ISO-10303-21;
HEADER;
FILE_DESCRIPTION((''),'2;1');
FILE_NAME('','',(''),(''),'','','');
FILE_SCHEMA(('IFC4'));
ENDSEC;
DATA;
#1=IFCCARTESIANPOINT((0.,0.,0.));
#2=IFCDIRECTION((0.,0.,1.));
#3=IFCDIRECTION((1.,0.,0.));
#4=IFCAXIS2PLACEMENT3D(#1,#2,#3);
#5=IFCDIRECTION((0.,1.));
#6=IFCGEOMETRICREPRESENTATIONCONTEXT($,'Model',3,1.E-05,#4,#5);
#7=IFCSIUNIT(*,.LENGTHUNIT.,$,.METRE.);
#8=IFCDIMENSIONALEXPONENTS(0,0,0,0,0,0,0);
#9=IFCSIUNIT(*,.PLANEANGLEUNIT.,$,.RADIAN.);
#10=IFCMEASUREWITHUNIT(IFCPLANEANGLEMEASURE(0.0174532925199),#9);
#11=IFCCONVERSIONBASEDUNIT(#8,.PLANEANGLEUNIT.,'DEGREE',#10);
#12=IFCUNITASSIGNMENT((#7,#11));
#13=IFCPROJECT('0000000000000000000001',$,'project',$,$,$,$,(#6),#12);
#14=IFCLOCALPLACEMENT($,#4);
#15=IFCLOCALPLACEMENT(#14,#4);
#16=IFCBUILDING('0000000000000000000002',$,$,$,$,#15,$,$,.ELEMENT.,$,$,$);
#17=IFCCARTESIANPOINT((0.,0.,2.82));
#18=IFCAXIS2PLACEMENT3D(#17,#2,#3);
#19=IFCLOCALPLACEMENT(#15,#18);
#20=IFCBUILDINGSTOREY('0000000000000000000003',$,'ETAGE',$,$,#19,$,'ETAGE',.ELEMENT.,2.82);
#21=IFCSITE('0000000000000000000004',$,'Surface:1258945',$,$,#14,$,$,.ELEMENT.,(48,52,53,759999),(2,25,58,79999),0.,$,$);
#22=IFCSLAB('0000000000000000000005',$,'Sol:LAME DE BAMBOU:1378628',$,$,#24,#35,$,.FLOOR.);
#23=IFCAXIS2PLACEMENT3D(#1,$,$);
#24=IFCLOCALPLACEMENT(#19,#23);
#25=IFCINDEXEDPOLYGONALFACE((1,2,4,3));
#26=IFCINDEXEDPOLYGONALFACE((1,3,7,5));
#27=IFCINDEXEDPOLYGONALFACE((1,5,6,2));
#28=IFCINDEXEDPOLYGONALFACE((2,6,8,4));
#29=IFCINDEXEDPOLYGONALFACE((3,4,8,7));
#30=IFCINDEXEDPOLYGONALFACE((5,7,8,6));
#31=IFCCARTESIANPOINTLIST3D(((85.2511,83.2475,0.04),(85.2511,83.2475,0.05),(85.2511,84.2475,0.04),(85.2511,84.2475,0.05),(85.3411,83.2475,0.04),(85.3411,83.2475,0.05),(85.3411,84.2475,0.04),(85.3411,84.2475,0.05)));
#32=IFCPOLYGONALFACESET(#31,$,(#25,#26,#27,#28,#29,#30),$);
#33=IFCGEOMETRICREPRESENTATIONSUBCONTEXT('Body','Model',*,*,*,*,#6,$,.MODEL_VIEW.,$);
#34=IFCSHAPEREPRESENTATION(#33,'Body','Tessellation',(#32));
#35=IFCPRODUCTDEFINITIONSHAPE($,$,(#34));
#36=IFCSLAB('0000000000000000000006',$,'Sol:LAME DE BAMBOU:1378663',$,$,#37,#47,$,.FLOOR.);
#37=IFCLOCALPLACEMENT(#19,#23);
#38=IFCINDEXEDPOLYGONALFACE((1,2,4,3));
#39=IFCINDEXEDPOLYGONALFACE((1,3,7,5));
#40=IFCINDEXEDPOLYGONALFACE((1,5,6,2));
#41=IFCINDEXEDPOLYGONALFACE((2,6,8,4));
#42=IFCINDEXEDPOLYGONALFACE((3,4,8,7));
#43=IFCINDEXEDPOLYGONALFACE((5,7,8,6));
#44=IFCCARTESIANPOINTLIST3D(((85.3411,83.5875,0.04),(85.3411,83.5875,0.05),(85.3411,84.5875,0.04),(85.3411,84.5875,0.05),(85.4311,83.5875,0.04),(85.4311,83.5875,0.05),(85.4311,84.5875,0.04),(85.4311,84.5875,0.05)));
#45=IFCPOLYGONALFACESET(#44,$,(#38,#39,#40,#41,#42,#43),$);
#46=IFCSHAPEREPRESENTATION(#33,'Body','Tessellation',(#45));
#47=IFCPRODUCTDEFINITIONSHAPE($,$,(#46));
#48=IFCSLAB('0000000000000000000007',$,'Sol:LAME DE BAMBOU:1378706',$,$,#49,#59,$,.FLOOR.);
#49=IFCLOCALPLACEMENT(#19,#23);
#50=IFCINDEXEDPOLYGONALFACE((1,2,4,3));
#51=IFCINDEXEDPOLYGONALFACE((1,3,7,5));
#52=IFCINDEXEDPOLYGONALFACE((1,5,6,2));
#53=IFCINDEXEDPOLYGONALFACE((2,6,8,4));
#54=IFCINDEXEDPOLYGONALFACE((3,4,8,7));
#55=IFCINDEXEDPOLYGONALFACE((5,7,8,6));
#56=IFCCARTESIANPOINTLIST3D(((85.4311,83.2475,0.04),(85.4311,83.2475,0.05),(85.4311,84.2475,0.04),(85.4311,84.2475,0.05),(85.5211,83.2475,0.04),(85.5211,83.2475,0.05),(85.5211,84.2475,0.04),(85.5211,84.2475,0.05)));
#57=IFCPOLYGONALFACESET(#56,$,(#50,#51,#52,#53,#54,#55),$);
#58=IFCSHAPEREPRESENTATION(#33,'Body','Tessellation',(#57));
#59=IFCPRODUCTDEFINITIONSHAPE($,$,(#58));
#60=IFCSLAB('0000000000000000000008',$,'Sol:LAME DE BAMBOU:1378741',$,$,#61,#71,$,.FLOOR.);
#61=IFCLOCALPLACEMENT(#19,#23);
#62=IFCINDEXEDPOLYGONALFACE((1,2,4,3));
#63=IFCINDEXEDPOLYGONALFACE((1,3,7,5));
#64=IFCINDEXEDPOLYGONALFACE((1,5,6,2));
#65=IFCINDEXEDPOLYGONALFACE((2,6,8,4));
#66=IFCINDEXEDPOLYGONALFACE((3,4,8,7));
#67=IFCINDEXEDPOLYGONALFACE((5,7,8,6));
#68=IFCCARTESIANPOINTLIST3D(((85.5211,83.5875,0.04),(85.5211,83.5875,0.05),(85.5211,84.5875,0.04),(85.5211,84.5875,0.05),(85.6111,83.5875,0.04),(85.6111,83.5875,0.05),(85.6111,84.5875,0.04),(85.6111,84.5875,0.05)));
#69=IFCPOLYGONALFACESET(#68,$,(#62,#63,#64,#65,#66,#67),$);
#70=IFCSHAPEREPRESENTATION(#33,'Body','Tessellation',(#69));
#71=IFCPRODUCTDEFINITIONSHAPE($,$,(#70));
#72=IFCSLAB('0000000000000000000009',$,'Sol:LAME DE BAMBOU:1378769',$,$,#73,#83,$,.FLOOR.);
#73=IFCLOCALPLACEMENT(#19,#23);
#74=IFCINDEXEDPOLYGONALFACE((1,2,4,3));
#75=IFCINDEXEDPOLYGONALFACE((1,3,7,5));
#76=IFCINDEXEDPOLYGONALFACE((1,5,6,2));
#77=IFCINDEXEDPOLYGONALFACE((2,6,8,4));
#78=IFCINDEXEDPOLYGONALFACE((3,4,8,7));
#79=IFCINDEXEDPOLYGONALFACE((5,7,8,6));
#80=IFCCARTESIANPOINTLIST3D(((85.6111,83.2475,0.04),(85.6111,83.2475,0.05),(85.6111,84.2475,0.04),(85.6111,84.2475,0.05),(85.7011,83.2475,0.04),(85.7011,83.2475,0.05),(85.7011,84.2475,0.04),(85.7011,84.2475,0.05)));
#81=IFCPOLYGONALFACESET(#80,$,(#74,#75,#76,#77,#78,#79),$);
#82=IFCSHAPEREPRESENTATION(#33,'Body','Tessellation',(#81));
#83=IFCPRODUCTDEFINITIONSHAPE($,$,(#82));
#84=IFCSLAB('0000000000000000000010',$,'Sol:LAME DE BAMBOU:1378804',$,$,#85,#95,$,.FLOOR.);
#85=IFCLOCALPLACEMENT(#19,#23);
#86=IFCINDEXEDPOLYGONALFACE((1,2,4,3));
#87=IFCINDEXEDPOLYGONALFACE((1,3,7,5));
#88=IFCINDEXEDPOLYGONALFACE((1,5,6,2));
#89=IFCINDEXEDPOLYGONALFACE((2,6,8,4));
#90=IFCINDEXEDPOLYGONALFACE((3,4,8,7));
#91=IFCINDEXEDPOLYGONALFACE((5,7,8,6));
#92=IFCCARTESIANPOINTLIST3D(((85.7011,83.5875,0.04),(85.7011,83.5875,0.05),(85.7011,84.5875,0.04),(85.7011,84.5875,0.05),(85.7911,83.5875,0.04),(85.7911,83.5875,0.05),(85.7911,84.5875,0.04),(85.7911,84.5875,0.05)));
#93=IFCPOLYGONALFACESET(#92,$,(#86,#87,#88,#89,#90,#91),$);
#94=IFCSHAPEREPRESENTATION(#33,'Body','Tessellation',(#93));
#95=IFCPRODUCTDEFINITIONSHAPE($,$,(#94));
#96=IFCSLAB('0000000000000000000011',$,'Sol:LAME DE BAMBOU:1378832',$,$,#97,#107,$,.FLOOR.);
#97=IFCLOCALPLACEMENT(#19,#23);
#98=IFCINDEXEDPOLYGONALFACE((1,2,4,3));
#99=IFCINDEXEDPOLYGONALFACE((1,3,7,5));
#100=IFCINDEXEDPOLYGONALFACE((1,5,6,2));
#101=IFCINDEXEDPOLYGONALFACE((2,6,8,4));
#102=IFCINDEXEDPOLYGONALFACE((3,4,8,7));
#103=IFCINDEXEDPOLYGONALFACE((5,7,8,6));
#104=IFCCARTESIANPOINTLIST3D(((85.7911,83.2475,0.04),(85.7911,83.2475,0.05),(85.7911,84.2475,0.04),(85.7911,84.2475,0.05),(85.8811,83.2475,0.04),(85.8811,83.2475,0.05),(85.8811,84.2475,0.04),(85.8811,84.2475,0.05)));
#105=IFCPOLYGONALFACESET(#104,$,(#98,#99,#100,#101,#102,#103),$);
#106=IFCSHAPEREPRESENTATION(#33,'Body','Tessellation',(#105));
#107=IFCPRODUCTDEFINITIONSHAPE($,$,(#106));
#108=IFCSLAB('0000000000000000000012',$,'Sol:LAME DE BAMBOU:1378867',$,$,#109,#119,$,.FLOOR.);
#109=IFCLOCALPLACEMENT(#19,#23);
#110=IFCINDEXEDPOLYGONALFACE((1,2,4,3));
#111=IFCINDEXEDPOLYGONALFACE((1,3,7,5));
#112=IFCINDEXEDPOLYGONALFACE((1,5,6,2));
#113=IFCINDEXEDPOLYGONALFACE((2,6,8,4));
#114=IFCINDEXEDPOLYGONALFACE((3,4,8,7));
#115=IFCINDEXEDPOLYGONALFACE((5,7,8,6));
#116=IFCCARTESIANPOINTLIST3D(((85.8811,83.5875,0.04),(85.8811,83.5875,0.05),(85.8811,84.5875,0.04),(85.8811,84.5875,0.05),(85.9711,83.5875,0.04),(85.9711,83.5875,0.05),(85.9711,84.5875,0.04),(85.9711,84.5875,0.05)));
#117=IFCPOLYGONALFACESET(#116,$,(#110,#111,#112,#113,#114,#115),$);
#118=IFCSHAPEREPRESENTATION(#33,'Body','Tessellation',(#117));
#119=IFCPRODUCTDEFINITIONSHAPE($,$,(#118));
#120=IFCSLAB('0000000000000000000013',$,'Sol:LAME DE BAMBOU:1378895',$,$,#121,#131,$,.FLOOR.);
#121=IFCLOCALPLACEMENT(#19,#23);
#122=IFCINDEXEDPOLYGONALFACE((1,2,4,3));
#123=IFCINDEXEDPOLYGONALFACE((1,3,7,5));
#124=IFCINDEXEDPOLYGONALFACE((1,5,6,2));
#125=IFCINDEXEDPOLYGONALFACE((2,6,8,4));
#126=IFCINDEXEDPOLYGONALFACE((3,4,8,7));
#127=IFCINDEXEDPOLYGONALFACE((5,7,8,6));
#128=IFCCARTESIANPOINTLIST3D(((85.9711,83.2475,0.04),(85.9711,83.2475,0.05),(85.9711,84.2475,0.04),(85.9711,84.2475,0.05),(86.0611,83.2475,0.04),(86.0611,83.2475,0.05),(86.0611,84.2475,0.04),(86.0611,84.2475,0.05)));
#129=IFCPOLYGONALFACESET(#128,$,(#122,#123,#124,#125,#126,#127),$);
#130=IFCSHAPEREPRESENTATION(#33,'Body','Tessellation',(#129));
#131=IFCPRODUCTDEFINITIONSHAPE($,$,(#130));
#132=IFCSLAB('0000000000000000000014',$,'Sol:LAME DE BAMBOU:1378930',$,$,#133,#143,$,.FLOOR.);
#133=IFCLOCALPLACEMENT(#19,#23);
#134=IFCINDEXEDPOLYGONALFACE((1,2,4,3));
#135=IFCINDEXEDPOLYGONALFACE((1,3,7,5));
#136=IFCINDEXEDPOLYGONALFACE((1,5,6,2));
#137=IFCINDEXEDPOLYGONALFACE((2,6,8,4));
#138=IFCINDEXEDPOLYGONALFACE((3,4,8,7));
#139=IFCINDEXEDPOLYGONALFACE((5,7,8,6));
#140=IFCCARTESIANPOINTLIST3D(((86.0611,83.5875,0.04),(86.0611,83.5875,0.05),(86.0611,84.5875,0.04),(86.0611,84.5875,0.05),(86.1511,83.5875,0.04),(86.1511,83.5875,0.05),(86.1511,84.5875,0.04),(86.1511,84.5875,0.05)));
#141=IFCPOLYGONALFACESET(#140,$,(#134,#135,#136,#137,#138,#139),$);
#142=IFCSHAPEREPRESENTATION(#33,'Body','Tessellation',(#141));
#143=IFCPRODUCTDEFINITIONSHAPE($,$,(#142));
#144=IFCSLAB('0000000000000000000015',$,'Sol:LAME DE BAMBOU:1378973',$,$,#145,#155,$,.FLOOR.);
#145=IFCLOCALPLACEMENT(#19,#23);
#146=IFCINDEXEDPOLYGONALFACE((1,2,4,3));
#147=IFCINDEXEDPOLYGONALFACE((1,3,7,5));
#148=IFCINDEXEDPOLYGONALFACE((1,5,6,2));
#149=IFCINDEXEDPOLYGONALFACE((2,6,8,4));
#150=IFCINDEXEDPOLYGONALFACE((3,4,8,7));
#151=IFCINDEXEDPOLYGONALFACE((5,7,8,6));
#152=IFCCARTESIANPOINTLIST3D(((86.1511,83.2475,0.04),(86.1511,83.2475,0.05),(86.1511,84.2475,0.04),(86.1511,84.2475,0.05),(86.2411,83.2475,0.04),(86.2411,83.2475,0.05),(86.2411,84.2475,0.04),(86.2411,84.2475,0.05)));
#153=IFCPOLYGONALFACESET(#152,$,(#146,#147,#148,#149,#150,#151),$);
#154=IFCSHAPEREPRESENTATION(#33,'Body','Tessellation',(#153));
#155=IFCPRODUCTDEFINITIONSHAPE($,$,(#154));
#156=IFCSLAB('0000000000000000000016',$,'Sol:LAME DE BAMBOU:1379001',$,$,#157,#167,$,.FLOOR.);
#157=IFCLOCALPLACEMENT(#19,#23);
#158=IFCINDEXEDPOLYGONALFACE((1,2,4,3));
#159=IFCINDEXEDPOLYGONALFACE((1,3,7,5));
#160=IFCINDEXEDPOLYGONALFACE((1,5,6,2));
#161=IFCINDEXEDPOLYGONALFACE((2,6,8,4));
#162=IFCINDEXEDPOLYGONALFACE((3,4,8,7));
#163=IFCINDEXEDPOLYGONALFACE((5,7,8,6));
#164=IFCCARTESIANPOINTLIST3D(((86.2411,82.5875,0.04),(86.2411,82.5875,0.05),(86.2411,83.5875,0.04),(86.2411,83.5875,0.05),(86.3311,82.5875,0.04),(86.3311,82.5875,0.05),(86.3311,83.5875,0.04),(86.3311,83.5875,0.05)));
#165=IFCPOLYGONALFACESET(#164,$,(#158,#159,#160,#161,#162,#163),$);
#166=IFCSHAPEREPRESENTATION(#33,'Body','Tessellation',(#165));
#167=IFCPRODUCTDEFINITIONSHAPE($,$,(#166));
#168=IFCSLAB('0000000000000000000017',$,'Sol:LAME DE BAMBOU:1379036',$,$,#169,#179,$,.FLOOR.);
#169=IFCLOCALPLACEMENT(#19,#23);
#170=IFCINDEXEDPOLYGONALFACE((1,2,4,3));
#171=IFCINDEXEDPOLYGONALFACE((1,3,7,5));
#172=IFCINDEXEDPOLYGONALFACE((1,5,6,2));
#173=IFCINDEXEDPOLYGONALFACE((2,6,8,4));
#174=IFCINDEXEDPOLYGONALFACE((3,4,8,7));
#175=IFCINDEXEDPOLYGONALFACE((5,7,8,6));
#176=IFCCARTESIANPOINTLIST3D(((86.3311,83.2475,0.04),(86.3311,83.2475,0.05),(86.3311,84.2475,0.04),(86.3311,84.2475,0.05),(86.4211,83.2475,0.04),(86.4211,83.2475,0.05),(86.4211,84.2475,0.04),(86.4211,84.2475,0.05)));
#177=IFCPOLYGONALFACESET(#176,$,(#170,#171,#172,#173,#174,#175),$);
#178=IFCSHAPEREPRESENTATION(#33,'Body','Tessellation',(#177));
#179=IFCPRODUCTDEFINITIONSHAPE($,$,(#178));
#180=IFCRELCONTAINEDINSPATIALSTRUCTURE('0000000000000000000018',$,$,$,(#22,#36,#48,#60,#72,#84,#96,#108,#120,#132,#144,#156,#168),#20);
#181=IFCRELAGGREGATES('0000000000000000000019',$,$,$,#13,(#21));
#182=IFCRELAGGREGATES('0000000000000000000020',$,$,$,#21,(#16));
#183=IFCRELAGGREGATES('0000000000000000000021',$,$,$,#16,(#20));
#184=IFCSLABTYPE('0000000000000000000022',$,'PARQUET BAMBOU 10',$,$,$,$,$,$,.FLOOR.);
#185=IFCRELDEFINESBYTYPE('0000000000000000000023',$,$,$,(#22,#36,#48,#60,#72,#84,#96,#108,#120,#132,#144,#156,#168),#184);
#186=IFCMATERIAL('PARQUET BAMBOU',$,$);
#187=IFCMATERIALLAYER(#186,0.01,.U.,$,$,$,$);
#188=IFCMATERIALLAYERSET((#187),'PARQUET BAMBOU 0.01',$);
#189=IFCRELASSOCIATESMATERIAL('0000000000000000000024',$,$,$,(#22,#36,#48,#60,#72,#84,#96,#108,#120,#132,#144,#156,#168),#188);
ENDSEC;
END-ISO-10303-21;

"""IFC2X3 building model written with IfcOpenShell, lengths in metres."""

from ifc_helpers import new_model, entity, si_unit, converted_unit, direction, frame, origin_with_axes, place, context, subcontext, project, spatial, polyline, outline, extrude, material, layer, layer_set, layer_usage, type_object, element, save


model = new_model("IFC2X3")

# Units and contexts
model_context = context("Model", 3, precision=1e-05, world=origin_with_axes(), true_north=direction((0.0, 1.0)))
body_context = subcontext(model_context, "Body", "Model", "MODEL_VIEW")
ifc_project = project(units=[si_unit("LENGTHUNIT", "METRE"), converted_unit("PLANEANGLEUNIT", "DEGREE", entity("IfcPlaneAngleMeasure", 0.0174532925199), si_unit("PLANEANGLEUNIT", "RADIAN"), dimensions=[0, 0, 0, 0, 0, 0, 0])], contexts=[model_context])

# Site, building, storey
site_placement = place(None, origin_with_axes())
site = spatial("IfcSite", under=ifc_project, at=site_placement, Name="Surface:1258945", CompositionType="ELEMENT", RefLatitude=(48, 52, 53, 759999), RefLongitude=(2, 25, 58, 79999), RefElevation=0.0)
building_placement = place(site_placement, origin_with_axes())
building = spatial("IfcBuilding", under=site, at=building_placement, CompositionType="ELEMENT")
storey_placement = place(building_placement, frame((0.0, 0.0, 2.82), z_axis=(0.0, 0.0, 1.0), x_axis=(1.0, 0.0, 0.0)))
storey = spatial("IfcBuildingStorey", under=building, at=storey_placement, Name="ETAGE", LongName="ETAGE", CompositionType="ELEMENT", Elevation=2.82)

# Slabs
ifc_material_1 = material(Name="PARQUET BAMBOU")
ifc_layer_1 = layer(ifc_material_1, 0.01, ventilated="UNKNOWN")
ifc_layer_set_1 = layer_set([ifc_layer_1], Name="PARQUET BAMBOU 0.01")
ifc_layer_usage_1 = layer_usage(ifc_layer_set_1, "AXIS3", "NEGATIVE", 0.01)
slab_type = type_object("IfcSlabType", Name="PARQUET BAMBOU 10", PredefinedType="FLOOR")
slab_1_placement = place(storey_placement, frame((85.2511, 84.2475, 0.05), z_axis=(0.0, 0.0, 1.0), x_axis=(1.0, 0.0, 0.0)))
element("IfcSlab", 1, at=slab_1_placement, inside=storey, type_object=slab_type, material=ifc_layer_usage_1, Name="Sol:LAME DE BAMBOU:1378628", PredefinedType="FLOOR", context=body_context, shape_type="SweptSolid", body=[
    extrude(outline(polyline([(0.0, 0.0), (0.0, -1.0), (0.09, -1.0), (0.09, 0.0), (0.0, 0.0)])), frame((0.0, 0.0, -0.01), z_axis=(0.0, 0.0, 1.0), x_axis=(1.0, 0.0, 0.0)), (0.0, 0.0, 1.0), 0.01),
])
ifc_layer_usage_2 = layer_usage(ifc_layer_set_1, "AXIS3", "NEGATIVE", 0.01)
slab_2_placement = place(storey_placement, frame((85.3411, 84.5875, 0.05), z_axis=(0.0, 0.0, 1.0), x_axis=(1.0, 0.0, 0.0)))
element("IfcSlab", 2, at=slab_2_placement, inside=storey, type_object=slab_type, material=ifc_layer_usage_2, Name="Sol:LAME DE BAMBOU:1378663", PredefinedType="FLOOR", context=body_context, shape_type="SweptSolid", body=[
    extrude(outline(polyline([(0.0, 0.0), (0.0, -1.0), (0.09, -1.0), (0.09, 0.0), (0.0, 0.0)])), frame((0.0, 0.0, -0.01), z_axis=(0.0, 0.0, 1.0), x_axis=(1.0, 0.0, 0.0)), (0.0, 0.0, 1.0), 0.01),
])
ifc_layer_usage_3 = layer_usage(ifc_layer_set_1, "AXIS3", "NEGATIVE", 0.01)
slab_3_placement = place(storey_placement, frame((85.4311, 84.2475, 0.05), z_axis=(0.0, 0.0, 1.0), x_axis=(1.0, 0.0, 0.0)))
element("IfcSlab", 3, at=slab_3_placement, inside=storey, type_object=slab_type, material=ifc_layer_usage_3, Name="Sol:LAME DE BAMBOU:1378706", PredefinedType="FLOOR", context=body_context, shape_type="SweptSolid", body=[
    extrude(outline(polyline([(0.0, 0.0), (0.0, -1.0), (0.09, -1.0), (0.09, 0.0), (0.0, 0.0)])), frame((0.0, 0.0, -0.01), z_axis=(0.0, 0.0, 1.0), x_axis=(1.0, 0.0, 0.0)), (0.0, 0.0, 1.0), 0.01),
])
ifc_layer_usage_4 = layer_usage(ifc_layer_set_1, "AXIS3", "NEGATIVE", 0.01)
slab_4_placement = place(storey_placement, frame((85.5211, 84.5875, 0.05), z_axis=(0.0, 0.0, 1.0), x_axis=(1.0, 0.0, 0.0)))
element("IfcSlab", 4, at=slab_4_placement, inside=storey, type_object=slab_type, material=ifc_layer_usage_4, Name="Sol:LAME DE BAMBOU:1378741", PredefinedType="FLOOR", context=body_context, shape_type="SweptSolid", body=[
    extrude(outline(polyline([(0.0, 0.0), (0.0, -1.0), (0.09, -1.0), (0.09, 0.0), (0.0, 0.0)])), frame((0.0, 0.0, -0.01), z_axis=(0.0, 0.0, 1.0), x_axis=(1.0, 0.0, 0.0)), (0.0, 0.0, 1.0), 0.01),
])
ifc_layer_usage_5 = layer_usage(ifc_layer_set_1, "AXIS3", "NEGATIVE", 0.01)
slab_5_placement = place(storey_placement, frame((85.6111, 84.2475, 0.05), z_axis=(0.0, 0.0, 1.0), x_axis=(1.0, 0.0, 0.0)))
element("IfcSlab", 5, at=slab_5_placement, inside=storey, type_object=slab_type, material=ifc_layer_usage_5, Name="Sol:LAME DE BAMBOU:1378769", PredefinedType="FLOOR", context=body_context, shape_type="SweptSolid", body=[
    extrude(outline(polyline([(0.0, 0.0), (0.0, -1.0), (0.09, -1.0), (0.09, 0.0), (0.0, 0.0)])), frame((0.0, 0.0, -0.01), z_axis=(0.0, 0.0, 1.0), x_axis=(1.0, 0.0, 0.0)), (0.0, 0.0, 1.0), 0.01),
])
ifc_layer_usage_6 = layer_usage(ifc_layer_set_1, "AXIS3", "NEGATIVE", 0.01)
slab_6_placement = place(storey_placement, frame((85.7011, 84.5875, 0.05), z_axis=(0.0, 0.0, 1.0), x_axis=(1.0, 0.0, 0.0)))
element("IfcSlab", 6, at=slab_6_placement, inside=storey, type_object=slab_type, material=ifc_layer_usage_6, Name="Sol:LAME DE BAMBOU:1378804", PredefinedType="FLOOR", context=body_context, shape_type="SweptSolid", body=[
    extrude(outline(polyline([(0.0, 0.0), (0.0, -1.0), (0.09, -1.0), (0.09, 0.0), (0.0, 0.0)])), frame((0.0, 0.0, -0.01), z_axis=(0.0, 0.0, 1.0), x_axis=(1.0, 0.0, 0.0)), (0.0, 0.0, 1.0), 0.01),
])
ifc_layer_usage_7 = layer_usage(ifc_layer_set_1, "AXIS3", "NEGATIVE", 0.01)
slab_7_placement = place(storey_placement, frame((85.7911, 84.2475, 0.05), z_axis=(0.0, 0.0, 1.0), x_axis=(1.0, 0.0, 0.0)))
element("IfcSlab", 7, at=slab_7_placement, inside=storey, type_object=slab_type, material=ifc_layer_usage_7, Name="Sol:LAME DE BAMBOU:1378832", PredefinedType="FLOOR", context=body_context, shape_type="SweptSolid", body=[
    extrude(outline(polyline([(0.0, 0.0), (0.0, -1.0), (0.09, -1.0), (0.09, 0.0), (0.0, 0.0)])), frame((0.0, 0.0, -0.01), z_axis=(0.0, 0.0, 1.0), x_axis=(1.0, 0.0, 0.0)), (0.0, 0.0, 1.0), 0.01),
])
ifc_layer_usage_8 = layer_usage(ifc_layer_set_1, "AXIS3", "NEGATIVE", 0.01)
slab_8_placement = place(storey_placement, frame((85.8811, 84.5875, 0.05), z_axis=(0.0, 0.0, 1.0), x_axis=(1.0, 0.0, 0.0)))
element("IfcSlab", 8, at=slab_8_placement, inside=storey, type_object=slab_type, material=ifc_layer_usage_8, Name="Sol:LAME DE BAMBOU:1378867", PredefinedType="FLOOR", context=body_context, shape_type="SweptSolid", body=[
    extrude(outline(polyline([(0.0, 0.0), (0.0, -1.0), (0.09, -1.0), (0.09, 0.0), (0.0, 0.0)])), frame((0.0, 0.0, -0.01), z_axis=(0.0, 0.0, 1.0), x_axis=(1.0, 0.0, 0.0)), (0.0, 0.0, 1.0), 0.01),
])
ifc_layer_usage_9 = layer_usage(ifc_layer_set_1, "AXIS3", "NEGATIVE", 0.01)
slab_9_placement = place(storey_placement, frame((85.9711, 84.2475, 0.05), z_axis=(0.0, 0.0, 1.0), x_axis=(1.0, 0.0, 0.0)))
element("IfcSlab", 9, at=slab_9_placement, inside=storey, type_object=slab_type, material=ifc_layer_usage_9, Name="Sol:LAME DE BAMBOU:1378895", PredefinedType="FLOOR", context=body_context, shape_type="SweptSolid", body=[
    extrude(outline(polyline([(0.0, 0.0), (0.0, -1.0), (0.09, -1.0), (0.09, 0.0), (0.0, 0.0)])), frame((0.0, 0.0, -0.01), z_axis=(0.0, 0.0, 1.0), x_axis=(1.0, 0.0, 0.0)), (0.0, 0.0, 1.0), 0.01),
])
ifc_layer_usage_10 = layer_usage(ifc_layer_set_1, "AXIS3", "NEGATIVE", 0.01)
slab_10_placement = place(storey_placement, frame((86.0611, 84.5875, 0.05), z_axis=(0.0, 0.0, 1.0), x_axis=(1.0, 0.0, 0.0)))
element("IfcSlab", 10, at=slab_10_placement, inside=storey, type_object=slab_type, material=ifc_layer_usage_10, Name="Sol:LAME DE BAMBOU:1378930", PredefinedType="FLOOR", context=body_context, shape_type="SweptSolid", body=[
    extrude(outline(polyline([(0.0, 0.0), (0.0, -1.0), (0.09, -1.0), (0.09, 0.0), (0.0, 0.0)])), frame((0.0, 0.0, -0.01), z_axis=(0.0, 0.0, 1.0), x_axis=(1.0, 0.0, 0.0)), (0.0, 0.0, 1.0), 0.01),
])
ifc_layer_usage_11 = layer_usage(ifc_layer_set_1, "AXIS3", "NEGATIVE", 0.01)
slab_11_placement = place(storey_placement, frame((86.1511, 84.2475, 0.05), z_axis=(0.0, 0.0, 1.0), x_axis=(1.0, 0.0, 0.0)))
element("IfcSlab", 11, at=slab_11_placement, inside=storey, type_object=slab_type, material=ifc_layer_usage_11, Name="Sol:LAME DE BAMBOU:1378973", PredefinedType="FLOOR", context=body_context, shape_type="SweptSolid", body=[
    extrude(outline(polyline([(0.0, 0.0), (0.0, -1.0), (0.09, -1.0), (0.09, 0.0), (0.0, 0.0)])), frame((0.0, 0.0, -0.01), z_axis=(0.0, 0.0, 1.0), x_axis=(1.0, 0.0, 0.0)), (0.0, 0.0, 1.0), 0.01),
])
ifc_layer_usage_12 = layer_usage(ifc_layer_set_1, "AXIS3", "NEGATIVE", 0.01)
slab_12_placement = place(storey_placement, frame((86.2411, 83.5875, 0.05), z_axis=(0.0, 0.0, 1.0), x_axis=(1.0, 0.0, 0.0)))
element("IfcSlab", 12, at=slab_12_placement, inside=storey, type_object=slab_type, material=ifc_layer_usage_12, Name="Sol:LAME DE BAMBOU:1379001", PredefinedType="FLOOR", context=body_context, shape_type="SweptSolid", body=[
    extrude(outline(polyline([(0.0, 0.0), (0.0, -1.0), (0.09, -1.0), (0.09, 0.0), (0.0, 0.0)])), frame((0.0, 0.0, -0.01), z_axis=(0.0, 0.0, 1.0), x_axis=(1.0, 0.0, 0.0)), (0.0, 0.0, 1.0), 0.01),
])
ifc_layer_usage_13 = layer_usage(ifc_layer_set_1, "AXIS3", "NEGATIVE", 0.01)
slab_13_placement = place(storey_placement, frame((86.3311, 84.2475, 0.05), z_axis=(0.0, 0.0, 1.0), x_axis=(1.0, 0.0, 0.0)))
element("IfcSlab", 13, at=slab_13_placement, inside=storey, type_object=slab_type, material=ifc_layer_usage_13, Name="Sol:LAME DE BAMBOU:1379036", PredefinedType="FLOOR", context=body_context, shape_type="SweptSolid", body=[
    extrude(outline(polyline([(0.0, 0.0), (0.0, -1.0), (0.09, -1.0), (0.09, 0.0), (0.0, 0.0)])), frame((0.0, 0.0, -0.01), z_axis=(0.0, 0.0, 1.0), x_axis=(1.0, 0.0, 0.0)), (0.0, 0.0, 1.0), 0.01),
])

save(model, "model.ifc")
